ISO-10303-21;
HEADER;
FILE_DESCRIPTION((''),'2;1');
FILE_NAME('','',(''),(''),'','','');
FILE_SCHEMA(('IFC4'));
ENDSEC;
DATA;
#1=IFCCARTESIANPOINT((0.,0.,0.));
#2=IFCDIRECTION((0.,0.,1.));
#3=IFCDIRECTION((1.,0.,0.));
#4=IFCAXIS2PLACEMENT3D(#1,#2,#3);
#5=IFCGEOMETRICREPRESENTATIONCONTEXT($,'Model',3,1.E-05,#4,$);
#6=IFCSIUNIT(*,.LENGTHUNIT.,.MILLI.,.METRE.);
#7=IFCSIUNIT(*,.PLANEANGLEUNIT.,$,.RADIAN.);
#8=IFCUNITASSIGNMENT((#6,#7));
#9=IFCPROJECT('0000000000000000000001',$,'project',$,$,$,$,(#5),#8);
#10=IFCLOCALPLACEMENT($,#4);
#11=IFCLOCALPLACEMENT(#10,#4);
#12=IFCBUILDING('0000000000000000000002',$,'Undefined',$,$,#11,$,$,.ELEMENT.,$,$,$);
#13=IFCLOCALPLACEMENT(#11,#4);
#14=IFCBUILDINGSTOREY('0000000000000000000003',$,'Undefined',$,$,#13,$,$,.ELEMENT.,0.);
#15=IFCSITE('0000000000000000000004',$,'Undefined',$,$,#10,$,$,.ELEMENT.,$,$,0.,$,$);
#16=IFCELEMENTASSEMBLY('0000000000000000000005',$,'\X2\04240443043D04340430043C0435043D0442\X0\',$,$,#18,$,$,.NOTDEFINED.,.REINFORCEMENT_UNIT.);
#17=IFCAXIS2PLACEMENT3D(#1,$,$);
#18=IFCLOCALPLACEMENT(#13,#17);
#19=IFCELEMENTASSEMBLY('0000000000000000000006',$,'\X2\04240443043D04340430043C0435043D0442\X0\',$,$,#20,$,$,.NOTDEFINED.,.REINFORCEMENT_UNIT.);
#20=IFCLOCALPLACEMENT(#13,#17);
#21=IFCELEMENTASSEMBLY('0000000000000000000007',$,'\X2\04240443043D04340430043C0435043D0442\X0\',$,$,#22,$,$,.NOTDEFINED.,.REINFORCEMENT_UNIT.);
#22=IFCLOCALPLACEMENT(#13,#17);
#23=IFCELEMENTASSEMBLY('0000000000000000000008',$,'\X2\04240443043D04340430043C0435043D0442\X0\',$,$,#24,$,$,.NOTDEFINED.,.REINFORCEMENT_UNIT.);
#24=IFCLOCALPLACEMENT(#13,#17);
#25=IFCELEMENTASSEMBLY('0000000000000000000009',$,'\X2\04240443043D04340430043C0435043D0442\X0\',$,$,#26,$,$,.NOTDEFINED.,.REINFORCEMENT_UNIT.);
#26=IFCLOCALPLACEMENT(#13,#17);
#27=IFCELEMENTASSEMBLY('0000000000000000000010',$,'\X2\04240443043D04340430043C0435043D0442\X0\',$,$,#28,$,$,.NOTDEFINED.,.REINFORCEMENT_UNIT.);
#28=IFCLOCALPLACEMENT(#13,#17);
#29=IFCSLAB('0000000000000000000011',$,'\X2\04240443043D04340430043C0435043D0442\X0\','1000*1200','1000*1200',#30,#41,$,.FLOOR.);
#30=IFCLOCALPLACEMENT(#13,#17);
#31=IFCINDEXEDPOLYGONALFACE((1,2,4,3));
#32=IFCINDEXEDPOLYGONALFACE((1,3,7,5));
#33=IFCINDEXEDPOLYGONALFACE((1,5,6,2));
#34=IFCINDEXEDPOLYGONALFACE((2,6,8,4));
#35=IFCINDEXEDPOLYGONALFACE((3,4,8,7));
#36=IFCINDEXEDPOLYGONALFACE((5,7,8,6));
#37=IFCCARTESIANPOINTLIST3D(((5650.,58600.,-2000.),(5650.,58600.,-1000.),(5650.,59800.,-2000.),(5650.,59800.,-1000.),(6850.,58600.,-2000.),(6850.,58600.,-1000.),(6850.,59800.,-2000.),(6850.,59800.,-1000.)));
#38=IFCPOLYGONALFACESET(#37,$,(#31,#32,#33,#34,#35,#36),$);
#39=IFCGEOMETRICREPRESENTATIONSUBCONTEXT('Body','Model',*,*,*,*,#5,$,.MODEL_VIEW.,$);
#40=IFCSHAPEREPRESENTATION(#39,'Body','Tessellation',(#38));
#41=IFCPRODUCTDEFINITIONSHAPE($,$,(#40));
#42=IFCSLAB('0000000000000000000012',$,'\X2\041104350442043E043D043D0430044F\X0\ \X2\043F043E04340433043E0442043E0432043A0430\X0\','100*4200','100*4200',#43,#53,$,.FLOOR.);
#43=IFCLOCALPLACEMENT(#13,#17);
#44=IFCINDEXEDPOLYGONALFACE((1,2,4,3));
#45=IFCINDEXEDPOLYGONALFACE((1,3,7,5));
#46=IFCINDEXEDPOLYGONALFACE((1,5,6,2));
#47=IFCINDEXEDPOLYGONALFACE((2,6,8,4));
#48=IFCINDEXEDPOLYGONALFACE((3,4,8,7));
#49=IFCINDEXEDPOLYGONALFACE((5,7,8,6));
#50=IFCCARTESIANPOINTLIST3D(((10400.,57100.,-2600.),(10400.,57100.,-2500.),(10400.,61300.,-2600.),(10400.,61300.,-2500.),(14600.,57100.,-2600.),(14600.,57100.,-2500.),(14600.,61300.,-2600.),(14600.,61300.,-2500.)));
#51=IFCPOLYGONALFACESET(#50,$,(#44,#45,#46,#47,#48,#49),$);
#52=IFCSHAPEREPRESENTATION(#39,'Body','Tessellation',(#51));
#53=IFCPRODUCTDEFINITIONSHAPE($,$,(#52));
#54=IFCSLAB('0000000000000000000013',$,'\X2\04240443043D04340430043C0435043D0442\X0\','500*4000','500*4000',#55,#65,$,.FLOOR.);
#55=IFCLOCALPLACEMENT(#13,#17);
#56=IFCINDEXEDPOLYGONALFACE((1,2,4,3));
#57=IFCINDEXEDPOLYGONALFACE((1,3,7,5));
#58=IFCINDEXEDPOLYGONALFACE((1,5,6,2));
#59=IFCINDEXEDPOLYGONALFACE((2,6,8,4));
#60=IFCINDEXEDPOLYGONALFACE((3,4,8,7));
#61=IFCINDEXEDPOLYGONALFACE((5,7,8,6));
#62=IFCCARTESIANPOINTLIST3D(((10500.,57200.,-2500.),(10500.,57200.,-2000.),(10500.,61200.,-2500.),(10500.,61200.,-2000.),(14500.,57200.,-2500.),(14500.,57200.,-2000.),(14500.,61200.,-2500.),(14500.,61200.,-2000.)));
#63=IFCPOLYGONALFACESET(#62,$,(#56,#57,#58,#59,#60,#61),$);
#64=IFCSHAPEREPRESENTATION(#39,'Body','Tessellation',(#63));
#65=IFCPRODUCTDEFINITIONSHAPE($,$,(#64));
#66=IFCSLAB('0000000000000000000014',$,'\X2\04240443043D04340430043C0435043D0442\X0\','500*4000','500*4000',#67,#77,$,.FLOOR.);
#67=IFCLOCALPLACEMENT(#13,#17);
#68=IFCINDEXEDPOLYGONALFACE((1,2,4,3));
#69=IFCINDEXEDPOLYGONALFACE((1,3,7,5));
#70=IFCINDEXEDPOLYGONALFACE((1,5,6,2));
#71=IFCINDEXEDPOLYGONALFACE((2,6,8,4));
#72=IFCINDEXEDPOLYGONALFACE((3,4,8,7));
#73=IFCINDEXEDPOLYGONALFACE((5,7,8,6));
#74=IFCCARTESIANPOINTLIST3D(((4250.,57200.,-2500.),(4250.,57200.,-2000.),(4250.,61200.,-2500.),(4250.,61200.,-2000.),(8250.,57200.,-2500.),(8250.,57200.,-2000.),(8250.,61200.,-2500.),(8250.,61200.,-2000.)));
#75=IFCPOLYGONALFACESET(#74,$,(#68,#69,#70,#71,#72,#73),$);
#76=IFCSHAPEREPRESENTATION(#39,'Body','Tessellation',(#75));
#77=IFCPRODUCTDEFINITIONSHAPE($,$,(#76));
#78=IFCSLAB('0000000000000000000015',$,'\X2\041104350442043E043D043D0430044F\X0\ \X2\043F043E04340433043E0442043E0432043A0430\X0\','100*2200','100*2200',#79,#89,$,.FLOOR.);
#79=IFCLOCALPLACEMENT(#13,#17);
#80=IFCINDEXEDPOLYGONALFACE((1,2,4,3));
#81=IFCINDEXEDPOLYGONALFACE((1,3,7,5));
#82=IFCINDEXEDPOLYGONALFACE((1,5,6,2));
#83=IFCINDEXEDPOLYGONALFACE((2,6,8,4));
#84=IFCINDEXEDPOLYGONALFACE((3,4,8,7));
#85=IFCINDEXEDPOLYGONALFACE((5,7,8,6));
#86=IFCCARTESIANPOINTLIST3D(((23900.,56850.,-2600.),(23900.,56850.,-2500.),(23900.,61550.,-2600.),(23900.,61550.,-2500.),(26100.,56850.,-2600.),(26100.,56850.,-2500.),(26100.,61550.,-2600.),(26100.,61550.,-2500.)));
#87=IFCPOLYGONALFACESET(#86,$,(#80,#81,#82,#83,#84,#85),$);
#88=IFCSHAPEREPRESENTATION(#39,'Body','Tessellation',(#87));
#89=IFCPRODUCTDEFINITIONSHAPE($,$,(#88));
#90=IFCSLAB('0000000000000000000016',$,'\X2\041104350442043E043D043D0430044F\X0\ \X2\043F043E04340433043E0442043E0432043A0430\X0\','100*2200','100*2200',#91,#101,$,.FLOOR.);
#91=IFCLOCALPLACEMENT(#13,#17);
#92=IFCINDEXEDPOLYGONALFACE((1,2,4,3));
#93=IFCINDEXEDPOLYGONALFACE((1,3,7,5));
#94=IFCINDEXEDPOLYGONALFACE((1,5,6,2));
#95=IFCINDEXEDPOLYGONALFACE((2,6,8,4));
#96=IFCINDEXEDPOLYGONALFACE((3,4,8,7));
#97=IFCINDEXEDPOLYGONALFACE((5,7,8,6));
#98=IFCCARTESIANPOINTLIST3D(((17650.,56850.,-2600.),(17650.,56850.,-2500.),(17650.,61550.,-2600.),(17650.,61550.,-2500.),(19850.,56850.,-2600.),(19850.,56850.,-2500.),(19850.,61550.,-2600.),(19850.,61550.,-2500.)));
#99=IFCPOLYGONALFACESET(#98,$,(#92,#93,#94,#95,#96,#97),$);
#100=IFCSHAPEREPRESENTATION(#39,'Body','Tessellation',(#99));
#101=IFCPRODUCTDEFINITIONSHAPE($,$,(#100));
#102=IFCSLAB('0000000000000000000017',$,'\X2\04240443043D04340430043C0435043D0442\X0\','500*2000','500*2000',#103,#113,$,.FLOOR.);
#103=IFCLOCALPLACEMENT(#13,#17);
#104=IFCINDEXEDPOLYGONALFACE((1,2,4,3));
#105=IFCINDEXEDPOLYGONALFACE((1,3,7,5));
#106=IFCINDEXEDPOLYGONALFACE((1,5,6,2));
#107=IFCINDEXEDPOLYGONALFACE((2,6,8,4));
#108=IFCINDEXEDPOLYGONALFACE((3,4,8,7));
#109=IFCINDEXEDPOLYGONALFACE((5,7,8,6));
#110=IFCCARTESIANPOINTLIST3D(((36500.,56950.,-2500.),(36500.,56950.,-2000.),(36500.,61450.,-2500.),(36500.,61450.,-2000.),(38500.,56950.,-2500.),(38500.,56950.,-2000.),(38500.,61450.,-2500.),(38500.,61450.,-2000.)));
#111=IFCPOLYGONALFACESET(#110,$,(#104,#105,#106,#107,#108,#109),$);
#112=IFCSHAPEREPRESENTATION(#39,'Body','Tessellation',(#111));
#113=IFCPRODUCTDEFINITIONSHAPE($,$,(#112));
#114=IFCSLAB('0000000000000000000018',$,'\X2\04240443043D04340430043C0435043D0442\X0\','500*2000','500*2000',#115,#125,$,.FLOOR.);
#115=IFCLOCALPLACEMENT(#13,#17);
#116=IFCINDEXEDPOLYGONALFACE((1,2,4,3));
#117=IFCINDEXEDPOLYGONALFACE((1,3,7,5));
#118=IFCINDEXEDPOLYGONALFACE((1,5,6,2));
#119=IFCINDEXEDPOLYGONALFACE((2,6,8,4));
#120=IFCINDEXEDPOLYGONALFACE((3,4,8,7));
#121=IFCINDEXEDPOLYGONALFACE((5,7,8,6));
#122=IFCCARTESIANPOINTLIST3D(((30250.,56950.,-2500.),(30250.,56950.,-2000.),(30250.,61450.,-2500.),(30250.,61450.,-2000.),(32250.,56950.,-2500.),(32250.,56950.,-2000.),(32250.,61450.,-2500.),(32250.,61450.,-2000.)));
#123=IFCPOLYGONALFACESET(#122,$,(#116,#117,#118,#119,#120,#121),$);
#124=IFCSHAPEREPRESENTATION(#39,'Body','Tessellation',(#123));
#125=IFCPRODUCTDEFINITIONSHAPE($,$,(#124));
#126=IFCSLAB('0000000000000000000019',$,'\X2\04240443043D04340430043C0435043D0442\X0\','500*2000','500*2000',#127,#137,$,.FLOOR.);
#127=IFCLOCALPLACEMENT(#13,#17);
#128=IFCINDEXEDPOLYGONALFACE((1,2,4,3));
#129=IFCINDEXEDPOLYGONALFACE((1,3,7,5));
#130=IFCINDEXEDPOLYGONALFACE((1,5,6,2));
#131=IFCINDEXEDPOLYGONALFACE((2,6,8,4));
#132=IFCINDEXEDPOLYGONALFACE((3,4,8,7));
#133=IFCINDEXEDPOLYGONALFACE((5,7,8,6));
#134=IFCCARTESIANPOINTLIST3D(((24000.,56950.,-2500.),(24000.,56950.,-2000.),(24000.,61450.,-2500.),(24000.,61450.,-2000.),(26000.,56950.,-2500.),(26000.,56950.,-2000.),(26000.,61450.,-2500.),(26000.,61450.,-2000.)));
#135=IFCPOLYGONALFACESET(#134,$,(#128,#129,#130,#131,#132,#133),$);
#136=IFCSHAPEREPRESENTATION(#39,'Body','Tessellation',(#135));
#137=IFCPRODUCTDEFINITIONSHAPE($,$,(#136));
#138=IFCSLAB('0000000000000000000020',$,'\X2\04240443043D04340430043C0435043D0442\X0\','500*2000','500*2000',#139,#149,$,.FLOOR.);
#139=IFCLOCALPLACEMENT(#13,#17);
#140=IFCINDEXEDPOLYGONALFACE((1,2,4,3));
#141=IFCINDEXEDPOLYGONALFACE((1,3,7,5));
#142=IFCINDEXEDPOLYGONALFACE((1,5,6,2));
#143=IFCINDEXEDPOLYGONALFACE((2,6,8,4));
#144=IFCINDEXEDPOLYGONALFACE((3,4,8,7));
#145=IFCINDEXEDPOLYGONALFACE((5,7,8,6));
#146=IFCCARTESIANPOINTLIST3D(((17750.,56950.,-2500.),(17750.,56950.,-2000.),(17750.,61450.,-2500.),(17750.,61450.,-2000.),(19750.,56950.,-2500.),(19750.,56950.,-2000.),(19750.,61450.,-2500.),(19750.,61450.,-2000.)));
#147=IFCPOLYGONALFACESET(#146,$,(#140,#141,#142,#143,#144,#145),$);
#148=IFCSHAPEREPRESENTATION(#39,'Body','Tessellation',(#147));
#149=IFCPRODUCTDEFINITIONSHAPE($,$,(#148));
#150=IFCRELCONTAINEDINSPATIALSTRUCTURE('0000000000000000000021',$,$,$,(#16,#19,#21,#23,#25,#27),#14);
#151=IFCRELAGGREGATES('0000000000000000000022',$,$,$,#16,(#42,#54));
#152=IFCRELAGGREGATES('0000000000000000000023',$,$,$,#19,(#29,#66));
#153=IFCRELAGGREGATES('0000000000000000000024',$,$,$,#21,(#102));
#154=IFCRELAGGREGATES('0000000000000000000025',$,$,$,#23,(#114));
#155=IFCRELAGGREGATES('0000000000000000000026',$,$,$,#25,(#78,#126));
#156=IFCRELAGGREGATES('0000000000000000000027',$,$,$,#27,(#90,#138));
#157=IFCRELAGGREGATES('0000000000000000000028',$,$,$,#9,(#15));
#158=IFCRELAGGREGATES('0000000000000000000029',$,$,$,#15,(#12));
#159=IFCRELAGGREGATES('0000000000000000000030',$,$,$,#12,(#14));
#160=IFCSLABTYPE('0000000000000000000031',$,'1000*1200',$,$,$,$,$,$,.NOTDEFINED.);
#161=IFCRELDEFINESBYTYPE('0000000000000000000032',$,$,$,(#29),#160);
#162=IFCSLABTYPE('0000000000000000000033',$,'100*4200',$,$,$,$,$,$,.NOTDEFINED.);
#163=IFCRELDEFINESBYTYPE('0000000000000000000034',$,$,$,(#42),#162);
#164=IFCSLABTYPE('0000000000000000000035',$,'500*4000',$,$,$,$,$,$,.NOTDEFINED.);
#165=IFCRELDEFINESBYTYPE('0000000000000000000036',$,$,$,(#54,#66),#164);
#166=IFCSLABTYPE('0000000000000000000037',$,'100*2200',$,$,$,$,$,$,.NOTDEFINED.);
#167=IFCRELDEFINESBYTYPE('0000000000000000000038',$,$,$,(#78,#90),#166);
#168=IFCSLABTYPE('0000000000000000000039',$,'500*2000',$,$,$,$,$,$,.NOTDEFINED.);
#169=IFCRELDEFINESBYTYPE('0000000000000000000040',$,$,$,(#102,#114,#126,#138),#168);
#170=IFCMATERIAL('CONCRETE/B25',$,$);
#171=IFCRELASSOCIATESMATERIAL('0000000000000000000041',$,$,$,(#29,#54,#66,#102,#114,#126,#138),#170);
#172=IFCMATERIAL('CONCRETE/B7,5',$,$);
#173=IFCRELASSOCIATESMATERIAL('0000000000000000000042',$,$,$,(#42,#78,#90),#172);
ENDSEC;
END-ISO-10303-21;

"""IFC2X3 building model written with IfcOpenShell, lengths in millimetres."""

from ifc_helpers import new_model, si_unit, frame, origin_with_axes, place, context, subcontext, project, spatial, polyline, outline, extrude, material, type_object, element, aggregate, save


model = new_model("IFC2X3")

# Units and contexts
model_context = context("Model", 3, precision=1e-05, world=origin_with_axes())
body_context = subcontext(model_context, "Body", "Model", "MODEL_VIEW")
ifc_project = project(units=[si_unit("LENGTHUNIT", "METRE", prefix="MILLI"), si_unit("PLANEANGLEUNIT", "RADIAN")], contexts=[model_context])

# Site, building, storey
site_placement = place(None, origin_with_axes())
site = spatial("IfcSite", under=ifc_project, at=site_placement, Name="Undefined", CompositionType="ELEMENT", RefElevation=0.0)
building_placement = place(site_placement, origin_with_axes())
building = spatial("IfcBuilding", under=site, at=building_placement, Name="Undefined", CompositionType="ELEMENT")
storey_placement = place(building_placement, origin_with_axes())
storey = spatial("IfcBuildingStorey", under=building, at=storey_placement, Name="Undefined", CompositionType="ELEMENT", Elevation=0.0)

# Element assemblies
assembly_1_placement = place(storey_placement, origin_with_axes())
assembly_1 = element("IfcElementAssembly", 1, at=assembly_1_placement, inside=storey, Name="Фундамент", AssemblyPlace="NOTDEFINED", PredefinedType="REINFORCEMENT_UNIT")
ifc_material_1 = material(Name="CONCRETE/B25")
assembly_2_placement = place(storey_placement, origin_with_axes())
assembly_2 = element("IfcElementAssembly", 2, at=assembly_2_placement, inside=storey, Name="Фундамент", AssemblyPlace="NOTDEFINED", PredefinedType="REINFORCEMENT_UNIT")
assembly_3_placement = place(storey_placement, origin_with_axes())
assembly_3 = element("IfcElementAssembly", 3, at=assembly_3_placement, inside=storey, Name="Фундамент", AssemblyPlace="NOTDEFINED", PredefinedType="REINFORCEMENT_UNIT")
assembly_4_placement = place(storey_placement, origin_with_axes())
assembly_4 = element("IfcElementAssembly", 4, at=assembly_4_placement, inside=storey, Name="Фундамент", AssemblyPlace="NOTDEFINED", PredefinedType="REINFORCEMENT_UNIT")
assembly_5_placement = place(storey_placement, origin_with_axes())
assembly_5 = element("IfcElementAssembly", 5, at=assembly_5_placement, inside=storey, Name="Фундамент", AssemblyPlace="NOTDEFINED", PredefinedType="REINFORCEMENT_UNIT")
assembly_6_placement = place(storey_placement, origin_with_axes())
assembly_6 = element("IfcElementAssembly", 6, at=assembly_6_placement, inside=storey, Name="Фундамент", AssemblyPlace="NOTDEFINED", PredefinedType="REINFORCEMENT_UNIT")

# Slabs
slab_type_1 = type_object("IfcSlabType", Name="1000*1200", PredefinedType="NOTDEFINED")
slab_1_placement = place(assembly_2_placement, frame((5650.0, 59800.0, -1500.0), z_axis=(0.0, 0.0, 1.0), x_axis=(0.0, -1.0, 0.0)))
slab_1 = element("IfcSlab", 7, at=slab_1_placement, type_object=slab_type_1, material=ifc_material_1, Name="Фундамент", Description="1000*1200", ObjectType="1000*1200", PredefinedType="FLOOR", context=body_context, shape_type="SweptSolid", body=[
    extrude(outline(polyline([(0.0, 0.0), (1200.0, 0.0), (1200.0, 1200.0), (0.0, 1200.0), (0.0, 0.0)])), frame((0.0, 0.0, -500.0), z_axis=(0.0, 0.0, 1.0), x_axis=(1.0, 0.0, 0.0)), (0.0, 0.0, 1.0), 1000.0),
])
ifc_material_2 = material(Name="CONCRETE/B7,5")
slab_type_2 = type_object("IfcSlabType", Name="100*4200", PredefinedType="NOTDEFINED")
slab_2_placement = place(assembly_1_placement, frame((10400.0, 61300.0, -2550.0), z_axis=(0.0, 0.0, 1.0), x_axis=(0.0, -1.0, 0.0)))
slab_2 = element("IfcSlab", 8, at=slab_2_placement, type_object=slab_type_2, material=ifc_material_2, Name="Бетонная подготовка", Description="100*4200", ObjectType="100*4200", PredefinedType="FLOOR", context=body_context, shape_type="SweptSolid", body=[
    extrude(outline(polyline([(0.0, 0.0), (4200.0, 0.0), (4200.0, 4200.0), (0.0, 4200.0), (0.0, 0.0)])), frame((0.0, 0.0, -50.0), z_axis=(0.0, 0.0, 1.0), x_axis=(1.0, 0.0, 0.0)), (0.0, 0.0, 1.0), 100.0),
])
slab_type_3 = type_object("IfcSlabType", Name="500*4000", PredefinedType="NOTDEFINED")
slab_3_placement = place(assembly_1_placement, frame((10500.0, 61200.0, -2250.0), z_axis=(0.0, 0.0, 1.0), x_axis=(0.0, -1.0, 0.0)))
slab_3 = element("IfcSlab", 9, at=slab_3_placement, type_object=slab_type_3, material=ifc_material_1, Name="Фундамент", Description="500*4000", ObjectType="500*4000", PredefinedType="FLOOR", context=body_context, shape_type="SweptSolid", body=[
    extrude(outline(polyline([(0.0, 0.0), (4000.0, 0.0), (4000.0, 4000.0), (0.0, 4000.0), (0.0, 0.0)])), frame((0.0, 0.0, -250.0), z_axis=(0.0, 0.0, 1.0), x_axis=(1.0, 0.0, 0.0)), (0.0, 0.0, 1.0), 500.0),
])
aggregate(assembly_1, [slab_2, slab_3])
slab_4_placement = place(assembly_2_placement, frame((4250.0, 61200.0, -2250.0), z_axis=(0.0, 0.0, 1.0), x_axis=(0.0, -1.0, 0.0)))
slab_4 = element("IfcSlab", 10, at=slab_4_placement, type_object=slab_type_3, material=ifc_material_1, Name="Фундамент", Description="500*4000", ObjectType="500*4000", PredefinedType="FLOOR", context=body_context, shape_type="SweptSolid", body=[
    extrude(outline(polyline([(0.0, 0.0), (4000.0, 0.0), (4000.0, 4000.0), (0.0, 4000.0), (0.0, 0.0)])), frame((0.0, 0.0, -250.0), z_axis=(0.0, 0.0, 1.0), x_axis=(1.0, 0.0, 0.0)), (0.0, 0.0, 1.0), 500.0),
])
aggregate(assembly_2, [slab_1, slab_4])
slab_type_4 = type_object("IfcSlabType", Name="100*2200", PredefinedType="NOTDEFINED")
slab_5_placement = place(assembly_5_placement, frame((23900.0, 61550.0, -2550.0), z_axis=(0.0, 0.0, 1.0), x_axis=(0.0, -1.0, 0.0)))
slab_5 = element("IfcSlab", 11, at=slab_5_placement, type_object=slab_type_4, material=ifc_material_2, Name="Бетонная подготовка", Description="100*2200", ObjectType="100*2200", PredefinedType="FLOOR", context=body_context, shape_type="SweptSolid", body=[
    extrude(outline(polyline([(0.0, 0.0), (4700.0, 0.0), (4700.0, 2200.0), (0.0, 2200.0), (0.0, 0.0)])), frame((0.0, 0.0, -50.0), z_axis=(0.0, 0.0, 1.0), x_axis=(1.0, 0.0, 0.0)), (0.0, 0.0, 1.0), 100.0),
])
slab_6_placement = place(assembly_6_placement, frame((17650.0, 61550.0, -2550.0), z_axis=(0.0, 0.0, 1.0), x_axis=(0.0, -1.0, 0.0)))
slab_6 = element("IfcSlab", 12, at=slab_6_placement, type_object=slab_type_4, material=ifc_material_2, Name="Бетонная подготовка", Description="100*2200", ObjectType="100*2200", PredefinedType="FLOOR", context=body_context, shape_type="SweptSolid", body=[
    extrude(outline(polyline([(0.0, 0.0), (4700.0, 0.0), (4700.0, 2200.0), (0.0, 2200.0), (0.0, 0.0)])), frame((0.0, 0.0, -50.0), z_axis=(0.0, 0.0, 1.0), x_axis=(1.0, 0.0, 0.0)), (0.0, 0.0, 1.0), 100.0),
])
slab_type_5 = type_object("IfcSlabType", Name="500*2000", PredefinedType="NOTDEFINED")
slab_7_placement = place(assembly_3_placement, frame((36500.0, 61450.0, -2250.0), z_axis=(0.0, 0.0, 1.0), x_axis=(0.0, -1.0, 0.0)))
slab_7 = element("IfcSlab", 13, at=slab_7_placement, type_object=slab_type_5, material=ifc_material_1, Name="Фундамент", Description="500*2000", ObjectType="500*2000", PredefinedType="FLOOR", context=body_context, shape_type="SweptSolid", body=[
    extrude(outline(polyline([(0.0, 0.0), (4500.0, 0.0), (4500.0, 2000.0), (0.0, 2000.0), (0.0, 0.0)])), frame((0.0, 0.0, -250.0), z_axis=(0.0, 0.0, 1.0), x_axis=(1.0, 0.0, 0.0)), (0.0, 0.0, 1.0), 500.0),
])
aggregate(assembly_3, [slab_7])
slab_8_placement = place(assembly_4_placement, frame((30250.0, 61450.0, -2250.0), z_axis=(0.0, 0.0, 1.0), x_axis=(0.0, -1.0, 0.0)))
slab_8 = element("IfcSlab", 14, at=slab_8_placement, type_object=slab_type_5, material=ifc_material_1, Name="Фундамент", Description="500*2000", ObjectType="500*2000", PredefinedType="FLOOR", context=body_context, shape_type="SweptSolid", body=[
    extrude(outline(polyline([(0.0, 0.0), (4500.0, 0.0), (4500.0, 2000.0), (0.0, 2000.0), (0.0, 0.0)])), frame((0.0, 0.0, -250.0), z_axis=(0.0, 0.0, 1.0), x_axis=(1.0, 0.0, 0.0)), (0.0, 0.0, 1.0), 500.0),
])
aggregate(assembly_4, [slab_8])
slab_9_placement = place(assembly_5_placement, frame((24000.0, 61450.0, -2250.0), z_axis=(0.0, 0.0, 1.0), x_axis=(0.0, -1.0, 0.0)))
slab_9 = element("IfcSlab", 15, at=slab_9_placement, type_object=slab_type_5, material=ifc_material_1, Name="Фундамент", Description="500*2000", ObjectType="500*2000", PredefinedType="FLOOR", context=body_context, shape_type="SweptSolid", body=[
    extrude(outline(polyline([(0.0, 0.0), (4500.0, 0.0), (4500.0, 2000.0), (0.0, 2000.0), (0.0, 0.0)])), frame((0.0, 0.0, -250.0), z_axis=(0.0, 0.0, 1.0), x_axis=(1.0, 0.0, 0.0)), (0.0, 0.0, 1.0), 500.0),
])
aggregate(assembly_5, [slab_5, slab_9])
slab_10_placement = place(assembly_6_placement, frame((17750.0, 61450.0, -2250.0), z_axis=(0.0, 0.0, 1.0), x_axis=(0.0, -1.0, 0.0)))
slab_10 = element("IfcSlab", 16, at=slab_10_placement, type_object=slab_type_5, material=ifc_material_1, Name="Фундамент", Description="500*2000", ObjectType="500*2000", PredefinedType="FLOOR", context=body_context, shape_type="SweptSolid", body=[
    extrude(outline(polyline([(0.0, 0.0), (4500.0, 0.0), (4500.0, 2000.0), (0.0, 2000.0), (0.0, 0.0)])), frame((0.0, 0.0, -250.0), z_axis=(0.0, 0.0, 1.0), x_axis=(1.0, 0.0, 0.0)), (0.0, 0.0, 1.0), 500.0),
])
aggregate(assembly_6, [slab_6, slab_10])

save(model, "model.ifc")
